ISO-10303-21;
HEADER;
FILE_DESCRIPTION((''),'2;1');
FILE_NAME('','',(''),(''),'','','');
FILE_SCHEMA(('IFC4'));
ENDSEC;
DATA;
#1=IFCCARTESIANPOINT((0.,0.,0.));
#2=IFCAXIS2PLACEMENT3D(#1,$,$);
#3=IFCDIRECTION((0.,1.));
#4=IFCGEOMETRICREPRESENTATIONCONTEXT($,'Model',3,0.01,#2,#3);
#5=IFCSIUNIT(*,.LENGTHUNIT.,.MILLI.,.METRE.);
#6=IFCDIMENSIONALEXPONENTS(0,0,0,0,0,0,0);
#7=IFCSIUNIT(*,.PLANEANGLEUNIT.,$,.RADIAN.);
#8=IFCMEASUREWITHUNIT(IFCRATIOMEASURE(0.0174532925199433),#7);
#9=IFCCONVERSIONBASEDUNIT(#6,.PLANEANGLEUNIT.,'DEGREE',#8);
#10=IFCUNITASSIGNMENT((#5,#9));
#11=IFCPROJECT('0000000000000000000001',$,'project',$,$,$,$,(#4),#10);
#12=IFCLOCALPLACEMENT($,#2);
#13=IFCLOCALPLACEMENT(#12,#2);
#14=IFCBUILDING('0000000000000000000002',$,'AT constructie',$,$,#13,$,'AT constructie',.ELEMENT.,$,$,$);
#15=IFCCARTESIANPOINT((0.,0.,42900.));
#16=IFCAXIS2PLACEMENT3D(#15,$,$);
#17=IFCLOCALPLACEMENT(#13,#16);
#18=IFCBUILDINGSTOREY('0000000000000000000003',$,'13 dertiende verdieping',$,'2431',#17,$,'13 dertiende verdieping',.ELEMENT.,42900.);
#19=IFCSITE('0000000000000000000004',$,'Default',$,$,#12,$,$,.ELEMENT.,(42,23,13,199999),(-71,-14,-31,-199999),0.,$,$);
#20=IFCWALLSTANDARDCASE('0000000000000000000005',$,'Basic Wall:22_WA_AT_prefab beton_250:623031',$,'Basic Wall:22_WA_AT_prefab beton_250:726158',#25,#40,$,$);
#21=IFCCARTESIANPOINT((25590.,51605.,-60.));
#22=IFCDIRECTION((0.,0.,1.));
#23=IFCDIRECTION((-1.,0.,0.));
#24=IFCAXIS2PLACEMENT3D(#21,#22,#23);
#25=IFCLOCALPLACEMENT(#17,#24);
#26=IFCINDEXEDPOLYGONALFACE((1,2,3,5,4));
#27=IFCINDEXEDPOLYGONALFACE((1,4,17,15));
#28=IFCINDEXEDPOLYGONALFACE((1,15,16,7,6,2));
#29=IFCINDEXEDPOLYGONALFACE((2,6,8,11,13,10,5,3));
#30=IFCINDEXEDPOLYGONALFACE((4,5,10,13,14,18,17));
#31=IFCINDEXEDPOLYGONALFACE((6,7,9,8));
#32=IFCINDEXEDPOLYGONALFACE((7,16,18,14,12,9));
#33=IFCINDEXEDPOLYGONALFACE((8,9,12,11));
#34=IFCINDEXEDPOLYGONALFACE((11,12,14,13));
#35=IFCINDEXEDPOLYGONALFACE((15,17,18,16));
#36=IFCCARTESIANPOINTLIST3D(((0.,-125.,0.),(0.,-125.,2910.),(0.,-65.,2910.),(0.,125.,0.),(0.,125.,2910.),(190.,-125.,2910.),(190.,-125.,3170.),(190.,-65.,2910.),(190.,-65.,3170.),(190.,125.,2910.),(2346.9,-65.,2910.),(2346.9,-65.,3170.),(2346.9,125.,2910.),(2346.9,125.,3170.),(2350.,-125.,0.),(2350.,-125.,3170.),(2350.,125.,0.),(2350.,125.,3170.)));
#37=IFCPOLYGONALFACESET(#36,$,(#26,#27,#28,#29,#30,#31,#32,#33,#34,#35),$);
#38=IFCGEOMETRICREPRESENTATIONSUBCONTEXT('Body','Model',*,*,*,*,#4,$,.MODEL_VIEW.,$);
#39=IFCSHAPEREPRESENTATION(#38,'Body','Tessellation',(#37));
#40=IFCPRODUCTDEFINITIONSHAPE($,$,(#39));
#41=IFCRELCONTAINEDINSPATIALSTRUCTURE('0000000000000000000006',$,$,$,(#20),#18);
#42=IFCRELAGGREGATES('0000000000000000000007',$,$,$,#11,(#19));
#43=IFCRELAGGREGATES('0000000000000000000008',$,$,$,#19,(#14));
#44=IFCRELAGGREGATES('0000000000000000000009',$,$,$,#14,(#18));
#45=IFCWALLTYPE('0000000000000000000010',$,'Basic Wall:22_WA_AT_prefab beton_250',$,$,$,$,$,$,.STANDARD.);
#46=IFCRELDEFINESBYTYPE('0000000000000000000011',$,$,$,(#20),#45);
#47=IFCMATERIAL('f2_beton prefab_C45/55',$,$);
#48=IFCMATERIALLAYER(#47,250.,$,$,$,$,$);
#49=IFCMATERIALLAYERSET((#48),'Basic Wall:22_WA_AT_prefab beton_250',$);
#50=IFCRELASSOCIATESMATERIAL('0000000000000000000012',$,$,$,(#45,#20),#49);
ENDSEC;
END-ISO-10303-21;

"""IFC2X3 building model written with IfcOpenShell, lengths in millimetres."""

from ifc_helpers import new_model, entity, si_unit, converted_unit, direction, frame, frame_2d, origin, place, context, subcontext, project, spatial, rectangle, extrude, material, layer, layer_set, layer_usage, type_object, element, save


model = new_model("IFC2X3")

# Units and contexts
model_context = context("Model", 3, precision=0.01, world=origin(), true_north=direction((0.0, 1.0)))
body_context = subcontext(model_context, "Body", "Model", "MODEL_VIEW")
ifc_project = project(units=[si_unit("LENGTHUNIT", "METRE", prefix="MILLI"), converted_unit("PLANEANGLEUNIT", "DEGREE", entity("IfcRatioMeasure", 0.0174532925199433), si_unit("PLANEANGLEUNIT", "RADIAN"), dimensions=[0, 0, 0, 0, 0, 0, 0])], contexts=[model_context])

# Site, building, storey
site_placement = place(None, origin())
site = spatial("IfcSite", under=ifc_project, at=site_placement, Name="Default", CompositionType="ELEMENT", RefLatitude=(42, 23, 13, 199999), RefLongitude=(-71, -14, -31, -199999), RefElevation=0.0)
building_placement = place(site_placement, origin())
building = spatial("IfcBuilding", under=site, at=building_placement, Name="AT constructie", LongName="AT constructie", CompositionType="ELEMENT")
storey_placement = place(building_placement, frame((0.0, 0.0, 42900.0)))
storey = spatial("IfcBuildingStorey", under=building, at=storey_placement, Name="13 dertiende verdieping", ObjectType="2431", LongName="13 dertiende verdieping", CompositionType="ELEMENT", Elevation=42900.0)

# Wall, openings
ifc_material_1 = material(Name="f2_beton prefab_C45/55")
ifc_layer = layer(ifc_material_1, 250.0)
ifc_layer_set = layer_set([ifc_layer], Name="Basic Wall:22_WA_AT_prefab beton_250")
wall_type = type_object("IfcWallType", Name="Basic Wall:22_WA_AT_prefab beton_250", PredefinedType="STANDARD", material=ifc_layer_set)
ifc_layer_usage_1 = layer_usage(ifc_layer_set, "AXIS2", "NEGATIVE", 125.0)
wall_1_placement = place(storey_placement, frame((25590.0, 51605.0, -60.0), z_axis=(0.0, 0.0, 1.0), x_axis=(-1.0, 0.0, 0.0)))
wall_1 = element("IfcWallStandardCase", 1, at=wall_1_placement, inside=storey, type_object=wall_type, material=ifc_layer_usage_1, Name="Basic Wall:22_WA_AT_prefab beton_250:623031", ObjectType="Basic Wall:22_WA_AT_prefab beton_250:726158", context=body_context, shape_type="SweptSolid", body=[
    extrude(rectangle(XDim=2350.0, YDim=250.0, at=frame_2d((1175.0, 0.0), x_axis=(-1.0, 0.0))), origin(), (0.0, 0.0, 1.0), 3170.0),
])
opening_1_placement = place(wall_1_placement, origin())
element("IfcOpeningElement", 2, at=opening_1_placement, cuts=wall_1, ObjectType="Opening", context=body_context, shape_type="SweptSolid", body=[
    extrude(rectangle(XDim=260.0, YDim=190.0, at=frame_2d((0.0, 0.0), x_axis=(0.0, 1.0))), frame((95.0, -3775.0, 3040.0), z_axis=(0.0, 1.0, 0.0), x_axis=(1.0, 0.0, 0.0)), (0.0, 0.0, 1.0), 3900.0),
])
opening_2_placement = place(wall_1_placement, origin())
element("IfcOpeningElement", 3, at=opening_2_placement, cuts=wall_1, ObjectType="Recess", context=body_context, shape_type="SweptSolid", body=[
    extrude(rectangle(XDim=260.0, YDim=2355.8, at=frame_2d((0.0, 0.0), x_axis=(1.0, 0.0))), frame((1169.0, -65.0, 3040.0), z_axis=(0.0, 1.0, 0.0), x_axis=(0.0, 0.0, -1.0)), (0.0, 0.0, 1.0), 190.0),
])

save(model, "model.ifc")
